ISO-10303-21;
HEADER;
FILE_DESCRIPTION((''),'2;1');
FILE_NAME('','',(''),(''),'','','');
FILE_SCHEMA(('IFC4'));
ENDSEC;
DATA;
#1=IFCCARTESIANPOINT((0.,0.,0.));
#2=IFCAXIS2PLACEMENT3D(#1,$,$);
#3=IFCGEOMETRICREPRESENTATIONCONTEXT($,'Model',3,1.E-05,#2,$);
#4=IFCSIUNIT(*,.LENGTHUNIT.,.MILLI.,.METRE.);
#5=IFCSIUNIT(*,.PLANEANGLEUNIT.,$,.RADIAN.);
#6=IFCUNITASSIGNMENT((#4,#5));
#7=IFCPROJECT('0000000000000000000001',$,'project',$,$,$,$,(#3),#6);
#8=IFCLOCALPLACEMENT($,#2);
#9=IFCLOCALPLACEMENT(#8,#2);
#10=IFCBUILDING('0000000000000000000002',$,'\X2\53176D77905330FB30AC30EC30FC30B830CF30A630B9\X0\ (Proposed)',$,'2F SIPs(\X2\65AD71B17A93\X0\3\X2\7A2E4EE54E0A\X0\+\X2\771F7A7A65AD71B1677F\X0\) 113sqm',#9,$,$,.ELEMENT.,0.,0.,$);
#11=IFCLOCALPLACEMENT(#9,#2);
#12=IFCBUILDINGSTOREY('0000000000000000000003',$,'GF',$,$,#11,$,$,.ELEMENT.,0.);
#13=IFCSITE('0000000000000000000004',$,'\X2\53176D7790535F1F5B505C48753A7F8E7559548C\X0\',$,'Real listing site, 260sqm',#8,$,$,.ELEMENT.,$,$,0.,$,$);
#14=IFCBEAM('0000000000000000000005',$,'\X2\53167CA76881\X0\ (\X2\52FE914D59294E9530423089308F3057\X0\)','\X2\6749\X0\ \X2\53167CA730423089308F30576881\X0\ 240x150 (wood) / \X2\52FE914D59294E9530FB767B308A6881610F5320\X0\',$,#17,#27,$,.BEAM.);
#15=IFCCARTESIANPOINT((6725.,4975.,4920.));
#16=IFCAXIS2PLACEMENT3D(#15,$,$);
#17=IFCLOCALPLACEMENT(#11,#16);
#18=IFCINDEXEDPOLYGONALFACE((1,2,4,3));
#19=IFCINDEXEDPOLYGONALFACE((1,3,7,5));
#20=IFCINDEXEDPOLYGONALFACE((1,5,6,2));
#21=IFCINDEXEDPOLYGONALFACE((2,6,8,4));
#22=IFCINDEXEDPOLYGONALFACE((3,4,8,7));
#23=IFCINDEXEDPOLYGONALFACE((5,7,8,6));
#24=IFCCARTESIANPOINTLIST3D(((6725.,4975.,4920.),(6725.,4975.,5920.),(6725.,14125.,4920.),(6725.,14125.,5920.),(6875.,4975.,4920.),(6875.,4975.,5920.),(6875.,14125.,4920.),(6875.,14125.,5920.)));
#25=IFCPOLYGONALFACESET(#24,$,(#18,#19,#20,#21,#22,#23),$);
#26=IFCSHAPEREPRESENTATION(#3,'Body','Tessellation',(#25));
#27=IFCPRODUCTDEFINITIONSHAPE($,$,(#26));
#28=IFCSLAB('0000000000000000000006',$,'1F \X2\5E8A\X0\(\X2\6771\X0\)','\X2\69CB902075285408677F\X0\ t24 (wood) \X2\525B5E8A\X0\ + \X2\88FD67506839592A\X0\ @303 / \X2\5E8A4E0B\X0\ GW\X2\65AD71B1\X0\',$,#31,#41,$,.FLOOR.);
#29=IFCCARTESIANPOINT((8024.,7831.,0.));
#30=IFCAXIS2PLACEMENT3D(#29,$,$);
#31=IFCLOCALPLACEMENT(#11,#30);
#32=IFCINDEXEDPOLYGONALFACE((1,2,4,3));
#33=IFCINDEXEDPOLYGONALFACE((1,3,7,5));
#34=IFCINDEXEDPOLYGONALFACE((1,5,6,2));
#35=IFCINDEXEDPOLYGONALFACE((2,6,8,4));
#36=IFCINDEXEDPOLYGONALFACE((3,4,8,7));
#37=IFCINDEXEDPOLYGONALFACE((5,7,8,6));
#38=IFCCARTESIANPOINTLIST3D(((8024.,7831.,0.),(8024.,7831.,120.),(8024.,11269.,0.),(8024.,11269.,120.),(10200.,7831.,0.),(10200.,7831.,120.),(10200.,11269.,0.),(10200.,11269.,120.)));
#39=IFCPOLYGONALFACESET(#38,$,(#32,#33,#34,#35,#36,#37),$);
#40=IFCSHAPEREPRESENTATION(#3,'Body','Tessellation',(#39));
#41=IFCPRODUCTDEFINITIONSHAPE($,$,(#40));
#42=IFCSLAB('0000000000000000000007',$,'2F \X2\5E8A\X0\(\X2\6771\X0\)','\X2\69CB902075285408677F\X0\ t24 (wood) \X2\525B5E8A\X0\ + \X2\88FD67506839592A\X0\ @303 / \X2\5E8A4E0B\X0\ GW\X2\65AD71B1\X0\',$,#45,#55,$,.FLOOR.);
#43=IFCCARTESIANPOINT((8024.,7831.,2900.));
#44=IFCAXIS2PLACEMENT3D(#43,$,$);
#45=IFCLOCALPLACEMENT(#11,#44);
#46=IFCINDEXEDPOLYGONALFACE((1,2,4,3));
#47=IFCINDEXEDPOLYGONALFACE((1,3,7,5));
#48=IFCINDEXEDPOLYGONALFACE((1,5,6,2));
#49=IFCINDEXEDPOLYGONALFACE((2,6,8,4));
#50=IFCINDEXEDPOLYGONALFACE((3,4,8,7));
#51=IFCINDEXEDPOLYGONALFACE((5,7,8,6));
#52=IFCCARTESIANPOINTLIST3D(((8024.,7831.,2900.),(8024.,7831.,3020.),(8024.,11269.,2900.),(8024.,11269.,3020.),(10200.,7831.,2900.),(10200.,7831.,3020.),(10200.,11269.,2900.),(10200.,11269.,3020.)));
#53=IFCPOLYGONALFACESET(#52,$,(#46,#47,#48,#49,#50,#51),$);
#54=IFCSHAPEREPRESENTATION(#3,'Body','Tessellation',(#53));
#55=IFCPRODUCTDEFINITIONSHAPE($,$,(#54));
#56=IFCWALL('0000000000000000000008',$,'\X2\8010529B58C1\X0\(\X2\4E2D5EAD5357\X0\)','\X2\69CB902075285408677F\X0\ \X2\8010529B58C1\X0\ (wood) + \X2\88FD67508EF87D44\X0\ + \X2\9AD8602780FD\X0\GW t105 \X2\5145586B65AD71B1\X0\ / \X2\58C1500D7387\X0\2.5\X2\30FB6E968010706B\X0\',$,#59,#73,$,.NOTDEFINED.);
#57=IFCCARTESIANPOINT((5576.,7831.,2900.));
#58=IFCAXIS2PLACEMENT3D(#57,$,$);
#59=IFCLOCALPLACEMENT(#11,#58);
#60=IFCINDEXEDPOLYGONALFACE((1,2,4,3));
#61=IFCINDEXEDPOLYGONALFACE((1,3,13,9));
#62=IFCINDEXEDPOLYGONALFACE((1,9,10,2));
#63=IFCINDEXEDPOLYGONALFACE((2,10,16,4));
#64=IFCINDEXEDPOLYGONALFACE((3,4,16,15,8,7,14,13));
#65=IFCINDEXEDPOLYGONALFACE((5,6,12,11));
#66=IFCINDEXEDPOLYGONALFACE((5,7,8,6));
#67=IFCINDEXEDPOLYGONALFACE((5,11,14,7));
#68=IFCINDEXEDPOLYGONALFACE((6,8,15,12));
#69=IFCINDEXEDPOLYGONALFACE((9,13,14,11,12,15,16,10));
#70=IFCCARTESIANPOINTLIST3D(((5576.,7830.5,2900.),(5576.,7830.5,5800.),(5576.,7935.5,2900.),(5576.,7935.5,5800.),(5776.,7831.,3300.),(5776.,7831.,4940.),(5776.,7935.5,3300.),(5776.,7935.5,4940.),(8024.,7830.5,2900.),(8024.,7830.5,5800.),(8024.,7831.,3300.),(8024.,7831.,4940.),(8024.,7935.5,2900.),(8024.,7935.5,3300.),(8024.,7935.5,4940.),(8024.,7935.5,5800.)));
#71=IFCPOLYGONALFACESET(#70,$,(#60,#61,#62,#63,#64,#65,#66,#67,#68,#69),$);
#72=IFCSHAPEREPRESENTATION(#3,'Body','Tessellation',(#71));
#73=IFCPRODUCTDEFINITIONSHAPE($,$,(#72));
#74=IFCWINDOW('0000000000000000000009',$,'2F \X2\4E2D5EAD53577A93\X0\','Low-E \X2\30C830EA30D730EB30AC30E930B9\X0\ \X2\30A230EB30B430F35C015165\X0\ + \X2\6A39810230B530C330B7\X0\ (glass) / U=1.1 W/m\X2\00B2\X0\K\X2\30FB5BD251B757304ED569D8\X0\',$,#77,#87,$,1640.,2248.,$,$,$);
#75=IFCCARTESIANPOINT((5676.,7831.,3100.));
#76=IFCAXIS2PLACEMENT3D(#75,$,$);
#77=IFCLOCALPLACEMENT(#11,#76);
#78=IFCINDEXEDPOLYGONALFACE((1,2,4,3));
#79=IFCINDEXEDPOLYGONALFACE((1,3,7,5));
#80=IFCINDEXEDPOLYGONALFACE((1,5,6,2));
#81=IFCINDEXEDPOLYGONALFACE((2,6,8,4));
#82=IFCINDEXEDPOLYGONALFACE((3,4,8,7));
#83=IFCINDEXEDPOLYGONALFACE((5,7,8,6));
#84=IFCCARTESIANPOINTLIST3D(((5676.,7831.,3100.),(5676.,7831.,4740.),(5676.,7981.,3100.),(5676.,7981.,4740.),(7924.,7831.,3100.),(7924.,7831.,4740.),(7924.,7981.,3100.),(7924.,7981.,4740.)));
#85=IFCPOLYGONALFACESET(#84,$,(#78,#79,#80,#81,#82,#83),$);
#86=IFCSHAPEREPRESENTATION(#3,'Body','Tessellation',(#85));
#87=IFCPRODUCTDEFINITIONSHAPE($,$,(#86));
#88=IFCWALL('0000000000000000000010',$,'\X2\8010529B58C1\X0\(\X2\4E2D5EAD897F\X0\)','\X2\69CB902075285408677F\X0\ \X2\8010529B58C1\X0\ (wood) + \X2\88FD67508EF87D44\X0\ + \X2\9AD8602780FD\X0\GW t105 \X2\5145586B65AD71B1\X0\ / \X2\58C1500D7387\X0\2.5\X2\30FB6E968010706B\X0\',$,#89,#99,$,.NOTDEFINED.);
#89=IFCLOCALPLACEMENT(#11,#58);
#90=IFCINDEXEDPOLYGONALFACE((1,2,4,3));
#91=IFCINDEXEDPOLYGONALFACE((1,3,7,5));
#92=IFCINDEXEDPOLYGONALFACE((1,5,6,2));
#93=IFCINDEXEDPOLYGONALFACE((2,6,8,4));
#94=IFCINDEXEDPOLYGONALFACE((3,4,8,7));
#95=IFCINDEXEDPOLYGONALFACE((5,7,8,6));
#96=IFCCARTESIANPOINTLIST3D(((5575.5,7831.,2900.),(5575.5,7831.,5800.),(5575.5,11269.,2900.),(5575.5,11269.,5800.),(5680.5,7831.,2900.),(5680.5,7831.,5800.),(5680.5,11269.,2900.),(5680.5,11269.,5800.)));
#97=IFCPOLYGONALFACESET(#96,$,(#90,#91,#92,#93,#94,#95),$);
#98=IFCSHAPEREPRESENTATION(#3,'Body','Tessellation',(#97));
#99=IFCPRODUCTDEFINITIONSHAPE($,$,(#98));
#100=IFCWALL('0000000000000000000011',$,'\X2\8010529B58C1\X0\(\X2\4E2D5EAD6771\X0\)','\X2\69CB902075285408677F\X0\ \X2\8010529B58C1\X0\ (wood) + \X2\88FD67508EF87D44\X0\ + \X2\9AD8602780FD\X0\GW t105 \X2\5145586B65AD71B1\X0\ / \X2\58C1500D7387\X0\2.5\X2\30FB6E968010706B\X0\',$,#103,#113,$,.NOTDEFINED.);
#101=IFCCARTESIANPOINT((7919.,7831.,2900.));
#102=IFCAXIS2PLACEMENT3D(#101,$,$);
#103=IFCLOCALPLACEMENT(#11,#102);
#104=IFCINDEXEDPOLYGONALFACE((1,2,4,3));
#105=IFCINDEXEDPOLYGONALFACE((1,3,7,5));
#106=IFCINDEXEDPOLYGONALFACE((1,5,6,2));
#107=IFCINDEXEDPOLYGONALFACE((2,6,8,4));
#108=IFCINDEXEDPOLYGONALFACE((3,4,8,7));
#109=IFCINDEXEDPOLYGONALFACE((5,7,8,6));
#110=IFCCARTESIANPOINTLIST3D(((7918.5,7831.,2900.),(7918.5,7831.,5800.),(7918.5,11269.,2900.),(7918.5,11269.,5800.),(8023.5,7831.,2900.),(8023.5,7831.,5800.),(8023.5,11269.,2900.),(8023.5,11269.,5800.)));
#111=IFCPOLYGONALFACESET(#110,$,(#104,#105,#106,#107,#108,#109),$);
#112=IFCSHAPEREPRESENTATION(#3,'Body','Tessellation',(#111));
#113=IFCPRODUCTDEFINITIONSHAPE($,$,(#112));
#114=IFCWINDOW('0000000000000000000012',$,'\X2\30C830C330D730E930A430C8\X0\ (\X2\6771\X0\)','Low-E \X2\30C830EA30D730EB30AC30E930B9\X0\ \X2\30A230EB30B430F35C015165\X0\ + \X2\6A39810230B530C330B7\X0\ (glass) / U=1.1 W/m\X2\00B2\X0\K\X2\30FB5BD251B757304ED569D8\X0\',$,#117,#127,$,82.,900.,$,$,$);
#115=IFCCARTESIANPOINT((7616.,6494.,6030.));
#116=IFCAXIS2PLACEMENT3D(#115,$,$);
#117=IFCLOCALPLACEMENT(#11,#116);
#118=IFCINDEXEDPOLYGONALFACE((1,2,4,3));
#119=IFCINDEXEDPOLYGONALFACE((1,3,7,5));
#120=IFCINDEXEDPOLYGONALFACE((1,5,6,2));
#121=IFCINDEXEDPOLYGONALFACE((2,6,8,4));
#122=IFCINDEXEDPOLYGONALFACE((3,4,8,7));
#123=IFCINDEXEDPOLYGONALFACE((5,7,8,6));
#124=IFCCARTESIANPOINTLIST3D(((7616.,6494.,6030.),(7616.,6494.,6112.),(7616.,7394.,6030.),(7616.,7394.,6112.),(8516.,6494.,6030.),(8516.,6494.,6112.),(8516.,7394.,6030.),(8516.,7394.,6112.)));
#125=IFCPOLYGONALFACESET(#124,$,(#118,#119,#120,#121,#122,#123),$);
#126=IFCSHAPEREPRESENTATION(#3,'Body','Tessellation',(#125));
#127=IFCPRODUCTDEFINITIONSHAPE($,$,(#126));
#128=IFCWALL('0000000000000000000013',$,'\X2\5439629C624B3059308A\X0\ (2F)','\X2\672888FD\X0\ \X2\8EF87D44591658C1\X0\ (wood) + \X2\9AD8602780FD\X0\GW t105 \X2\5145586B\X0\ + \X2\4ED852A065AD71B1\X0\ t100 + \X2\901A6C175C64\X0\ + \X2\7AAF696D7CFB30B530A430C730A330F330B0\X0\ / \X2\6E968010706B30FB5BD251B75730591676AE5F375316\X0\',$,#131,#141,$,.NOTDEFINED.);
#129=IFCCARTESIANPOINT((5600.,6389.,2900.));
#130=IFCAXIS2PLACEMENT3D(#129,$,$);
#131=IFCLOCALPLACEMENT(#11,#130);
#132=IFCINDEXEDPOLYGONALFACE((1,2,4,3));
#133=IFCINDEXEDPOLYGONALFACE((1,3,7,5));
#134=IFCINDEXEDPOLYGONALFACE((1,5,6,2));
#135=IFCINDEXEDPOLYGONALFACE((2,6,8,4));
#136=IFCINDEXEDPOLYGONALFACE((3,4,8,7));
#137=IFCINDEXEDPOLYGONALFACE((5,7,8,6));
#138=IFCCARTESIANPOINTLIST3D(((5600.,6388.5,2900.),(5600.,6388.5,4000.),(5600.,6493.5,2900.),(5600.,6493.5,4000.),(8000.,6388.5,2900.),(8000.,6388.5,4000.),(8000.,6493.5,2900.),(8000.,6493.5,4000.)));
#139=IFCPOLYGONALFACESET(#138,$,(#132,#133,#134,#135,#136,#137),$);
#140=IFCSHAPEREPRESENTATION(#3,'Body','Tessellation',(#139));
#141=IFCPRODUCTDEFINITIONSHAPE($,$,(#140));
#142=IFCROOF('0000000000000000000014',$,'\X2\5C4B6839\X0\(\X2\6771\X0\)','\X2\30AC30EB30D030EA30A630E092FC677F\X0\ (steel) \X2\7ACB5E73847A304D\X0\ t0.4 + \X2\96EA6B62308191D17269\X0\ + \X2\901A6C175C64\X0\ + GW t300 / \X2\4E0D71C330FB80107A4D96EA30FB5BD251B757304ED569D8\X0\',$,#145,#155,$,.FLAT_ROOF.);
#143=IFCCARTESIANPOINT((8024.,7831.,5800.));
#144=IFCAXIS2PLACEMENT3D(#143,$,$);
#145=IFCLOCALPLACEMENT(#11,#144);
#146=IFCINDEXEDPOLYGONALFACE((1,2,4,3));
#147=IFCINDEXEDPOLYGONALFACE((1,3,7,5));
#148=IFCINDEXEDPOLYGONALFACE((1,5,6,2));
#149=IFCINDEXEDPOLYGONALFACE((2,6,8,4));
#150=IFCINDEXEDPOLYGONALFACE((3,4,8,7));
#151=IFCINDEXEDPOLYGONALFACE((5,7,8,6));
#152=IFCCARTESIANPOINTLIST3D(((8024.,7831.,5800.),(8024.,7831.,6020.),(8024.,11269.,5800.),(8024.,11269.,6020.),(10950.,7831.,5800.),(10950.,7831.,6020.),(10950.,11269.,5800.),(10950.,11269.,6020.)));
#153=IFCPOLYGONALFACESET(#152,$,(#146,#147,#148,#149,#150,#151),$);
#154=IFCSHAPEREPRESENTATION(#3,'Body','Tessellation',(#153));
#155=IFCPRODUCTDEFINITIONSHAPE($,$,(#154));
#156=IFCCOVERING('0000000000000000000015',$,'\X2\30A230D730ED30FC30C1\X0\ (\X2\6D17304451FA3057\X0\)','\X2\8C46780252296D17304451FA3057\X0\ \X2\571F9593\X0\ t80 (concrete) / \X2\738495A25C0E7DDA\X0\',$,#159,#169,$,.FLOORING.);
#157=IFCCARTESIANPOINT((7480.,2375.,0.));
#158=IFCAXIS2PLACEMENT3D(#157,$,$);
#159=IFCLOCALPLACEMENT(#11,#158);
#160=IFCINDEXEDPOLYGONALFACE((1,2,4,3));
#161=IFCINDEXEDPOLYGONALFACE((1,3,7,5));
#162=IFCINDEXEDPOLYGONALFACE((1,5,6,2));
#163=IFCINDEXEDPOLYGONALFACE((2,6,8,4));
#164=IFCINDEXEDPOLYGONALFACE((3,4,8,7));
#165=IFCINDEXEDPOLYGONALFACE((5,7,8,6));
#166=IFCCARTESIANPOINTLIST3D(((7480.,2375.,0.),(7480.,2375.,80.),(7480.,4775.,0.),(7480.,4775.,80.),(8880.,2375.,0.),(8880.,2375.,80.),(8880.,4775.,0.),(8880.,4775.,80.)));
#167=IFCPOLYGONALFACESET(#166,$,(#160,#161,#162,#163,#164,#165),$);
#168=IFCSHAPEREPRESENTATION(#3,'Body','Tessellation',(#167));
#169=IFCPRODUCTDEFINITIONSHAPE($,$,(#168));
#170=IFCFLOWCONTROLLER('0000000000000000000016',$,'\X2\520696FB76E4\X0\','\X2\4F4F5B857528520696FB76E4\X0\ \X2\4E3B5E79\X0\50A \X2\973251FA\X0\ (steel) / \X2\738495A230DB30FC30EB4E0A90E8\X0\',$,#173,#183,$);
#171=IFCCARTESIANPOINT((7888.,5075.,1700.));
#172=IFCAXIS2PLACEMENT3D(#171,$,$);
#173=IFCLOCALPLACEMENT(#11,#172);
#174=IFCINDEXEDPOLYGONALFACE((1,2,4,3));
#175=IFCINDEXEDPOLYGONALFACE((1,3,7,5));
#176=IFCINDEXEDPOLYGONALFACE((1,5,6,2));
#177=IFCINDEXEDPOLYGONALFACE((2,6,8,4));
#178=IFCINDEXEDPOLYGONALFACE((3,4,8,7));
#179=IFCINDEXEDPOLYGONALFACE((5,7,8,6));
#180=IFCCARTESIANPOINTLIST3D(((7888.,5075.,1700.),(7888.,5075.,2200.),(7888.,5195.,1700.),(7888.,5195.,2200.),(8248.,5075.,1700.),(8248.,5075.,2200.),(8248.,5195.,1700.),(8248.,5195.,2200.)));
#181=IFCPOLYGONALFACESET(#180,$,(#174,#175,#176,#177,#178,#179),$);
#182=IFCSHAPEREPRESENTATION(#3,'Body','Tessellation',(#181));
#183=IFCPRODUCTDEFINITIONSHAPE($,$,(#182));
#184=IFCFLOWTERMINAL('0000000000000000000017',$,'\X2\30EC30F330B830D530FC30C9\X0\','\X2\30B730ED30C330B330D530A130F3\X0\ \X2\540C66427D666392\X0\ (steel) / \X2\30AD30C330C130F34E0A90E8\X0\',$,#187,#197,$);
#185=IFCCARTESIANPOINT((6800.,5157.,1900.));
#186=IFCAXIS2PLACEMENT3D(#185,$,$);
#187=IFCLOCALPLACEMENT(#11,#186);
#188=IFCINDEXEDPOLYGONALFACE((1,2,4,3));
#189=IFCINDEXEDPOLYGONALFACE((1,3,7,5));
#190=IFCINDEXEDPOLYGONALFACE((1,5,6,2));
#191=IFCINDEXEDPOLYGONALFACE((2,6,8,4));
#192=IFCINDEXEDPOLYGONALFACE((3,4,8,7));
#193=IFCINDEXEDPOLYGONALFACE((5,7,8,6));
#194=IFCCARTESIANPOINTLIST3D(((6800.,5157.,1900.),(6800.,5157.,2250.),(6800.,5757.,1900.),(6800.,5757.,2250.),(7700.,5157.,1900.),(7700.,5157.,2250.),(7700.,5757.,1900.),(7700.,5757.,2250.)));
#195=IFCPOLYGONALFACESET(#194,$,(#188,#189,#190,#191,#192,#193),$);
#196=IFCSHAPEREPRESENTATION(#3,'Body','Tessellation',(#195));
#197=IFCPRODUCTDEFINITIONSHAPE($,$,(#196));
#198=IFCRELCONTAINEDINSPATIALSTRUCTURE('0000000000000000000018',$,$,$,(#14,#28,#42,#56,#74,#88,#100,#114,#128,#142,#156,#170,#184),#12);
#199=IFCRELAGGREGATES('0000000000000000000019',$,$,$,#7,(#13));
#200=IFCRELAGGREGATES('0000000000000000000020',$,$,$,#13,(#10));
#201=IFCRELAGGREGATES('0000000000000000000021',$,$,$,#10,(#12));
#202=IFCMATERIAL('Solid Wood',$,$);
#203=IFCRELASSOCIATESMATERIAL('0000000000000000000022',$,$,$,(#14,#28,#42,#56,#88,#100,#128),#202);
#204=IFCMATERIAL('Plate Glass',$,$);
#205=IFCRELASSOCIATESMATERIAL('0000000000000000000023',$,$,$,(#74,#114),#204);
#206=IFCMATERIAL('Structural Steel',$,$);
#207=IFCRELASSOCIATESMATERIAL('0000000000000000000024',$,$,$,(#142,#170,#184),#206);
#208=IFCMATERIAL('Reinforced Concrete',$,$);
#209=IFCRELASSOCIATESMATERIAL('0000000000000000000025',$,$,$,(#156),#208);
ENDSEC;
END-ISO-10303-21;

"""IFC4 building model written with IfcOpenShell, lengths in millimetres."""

from ifc_helpers import new_model, si_unit, frame, frame_2d, origin, place, context, project, spatial, rectangle, extrude, material, element, fill, save


model = new_model("IFC4")

# Units and contexts
model_context = context("Model", 3, precision=1e-05, world=origin())
ifc_project = project(units=[si_unit("LENGTHUNIT", "METRE", prefix="MILLI"), si_unit("PLANEANGLEUNIT", "RADIAN")], contexts=[model_context])

# Site, building, storey
site_placement = place(None, origin())
site = spatial("IfcSite", under=ifc_project, at=site_placement, Name="北海道弟子屈町美留和", ObjectType="Real listing site, 260sqm", CompositionType="ELEMENT", RefElevation=0.0)
building_placement = place(site_placement, origin())
building = spatial("IfcBuilding", under=site, at=building_placement, Name="北海道・ガレージハウス (Proposed)", ObjectType="2F SIPs(断熱窓3種以上+真空断熱板) 113sqm", CompositionType="ELEMENT", ElevationOfRefHeight=0.0, ElevationOfTerrain=0.0)
storey_placement = place(building_placement, origin())
storey = spatial("IfcBuildingStorey", under=building, at=storey_placement, Name="GF", CompositionType="ELEMENT", Elevation=0.0)

# Shared definitions
ifc_material_1 = material(Name="Solid Wood")

# Beam
beam_placement = place(storey_placement, frame((6725.0, 4975.0, 4920.0)))
element("IfcBeam", 1, at=beam_placement, inside=storey, material=ifc_material_1, Name="化粧梁 (勾配天井あらわし)", Description="杉 化粧あらわし梁 240x150 (wood) / 勾配天井・登り梁意匠", PredefinedType="BEAM", context=model_context, shape_type="SweptSolid", body=[
    extrude(rectangle(XDim=150.0, YDim=9150.0, at=frame_2d((75.0, 4575.0))), frame((6725.0, 4975.0, 4920.0)), (0.0, 0.0, 1.0), 1000.0),
])

# Slabs
slab_1_placement = place(storey_placement, frame((8024.0, 7831.0, 0.0)))
element("IfcSlab", 2, at=slab_1_placement, inside=storey, material=ifc_material_1, Name="1F 床(東)", Description="構造用合板 t24 (wood) 剛床 + 製材根太 @303 / 床下 GW断熱", PredefinedType="FLOOR", context=model_context, shape_type="SweptSolid", body=[
    extrude(rectangle(XDim=2176.0, YDim=3438.0, at=frame_2d((1088.0, 1719.0))), frame((8024.0, 7831.0, 0.0)), (0.0, 0.0, 1.0), 120.0),
])
slab_2_placement = place(storey_placement, frame((8024.0, 7831.0, 2900.0)))
element("IfcSlab", 3, at=slab_2_placement, inside=storey, material=ifc_material_1, Name="2F 床(東)", Description="構造用合板 t24 (wood) 剛床 + 製材根太 @303 / 床下 GW断熱", PredefinedType="FLOOR", context=model_context, shape_type="SweptSolid", body=[
    extrude(rectangle(XDim=2176.0, YDim=3438.0, at=frame_2d((1088.0, 1719.0))), frame((8024.0, 7831.0, 2900.0)), (0.0, 0.0, 1.0), 120.0),
])

# Wall, opening, window
wall_1_placement = place(storey_placement, frame((5576.0, 7831.0, 2900.0)))
wall_1 = element("IfcWall", 4, at=wall_1_placement, inside=storey, material=ifc_material_1, Name="耐力壁(中庭南)", Description="構造用合板 耐力壁 (wood) + 製材軸組 + 高性能GW t105 充填断熱 / 壁倍率2.5・準耐火", PredefinedType="NOTDEFINED", context=model_context, shape_type="SweptSolid", body=[
    extrude(rectangle(XDim=2448.0, YDim=105.0, at=frame_2d((1224.0, 52.0))), frame((5576.0, 7831.0, 2900.0)), (0.0, 0.0, 1.0), 2900.0),
])
opening_placement = place(storey_placement, frame((5676.0, 7831.0, 3100.0)))
opening = element("IfcOpeningElement", 5, at=opening_placement, cuts=wall_1, PredefinedType="NOTDEFINED", context=model_context, shape_type="SweptSolid", body=[
    extrude(rectangle(XDim=2248.0, YDim=150.0, at=frame_2d((1124.0, 75.0))), frame((5676.0, 7831.0, 3100.0)), (0.0, 0.0, 1.0), 1640.0),
])
ifc_material_2 = material(Name="Plate Glass")
window_1_placement = place(storey_placement, frame((5676.0, 7831.0, 3100.0)))
window_1 = element("IfcWindow", 6, at=window_1_placement, inside=storey, material=ifc_material_2, Name="2F 中庭南窓", Description="Low-E トリプルガラス アルゴン封入 + 樹脂サッシ (glass) / U=1.1 W/m²K・寒冷地仕様", OverallHeight=1640.0, OverallWidth=2248.0, context=model_context, shape_type="SweptSolid", body=[
    extrude(rectangle(XDim=2248.0, YDim=150.0, at=frame_2d((1124.0, 75.0))), frame((5676.0, 7831.0, 3100.0)), (0.0, 0.0, 1.0), 1640.0),
])
fill(opening, window_1)

# Walls
wall_2_placement = place(storey_placement, frame((5576.0, 7831.0, 2900.0)))
element("IfcWall", 7, at=wall_2_placement, inside=storey, material=ifc_material_1, Name="耐力壁(中庭西)", Description="構造用合板 耐力壁 (wood) + 製材軸組 + 高性能GW t105 充填断熱 / 壁倍率2.5・準耐火", PredefinedType="NOTDEFINED", context=model_context, shape_type="SweptSolid", body=[
    extrude(rectangle(XDim=105.0, YDim=3438.0, at=frame_2d((52.0, 1719.0))), frame((5576.0, 7831.0, 2900.0)), (0.0, 0.0, 1.0), 2900.0),
])
wall_3_placement = place(storey_placement, frame((7919.0, 7831.0, 2900.0)))
element("IfcWall", 8, at=wall_3_placement, inside=storey, material=ifc_material_1, Name="耐力壁(中庭東)", Description="構造用合板 耐力壁 (wood) + 製材軸組 + 高性能GW t105 充填断熱 / 壁倍率2.5・準耐火", PredefinedType="NOTDEFINED", context=model_context, shape_type="SweptSolid", body=[
    extrude(rectangle(XDim=105.0, YDim=3438.0, at=frame_2d((52.0, 1719.0))), frame((7919.0, 7831.0, 2900.0)), (0.0, 0.0, 1.0), 2900.0),
])

# Window
window_2_placement = place(storey_placement, frame((7616.0, 6494.0, 6030.0)))
element("IfcWindow", 9, at=window_2_placement, inside=storey, material=ifc_material_2, Name="トップライト (東)", Description="Low-E トリプルガラス アルゴン封入 + 樹脂サッシ (glass) / U=1.1 W/m²K・寒冷地仕様", OverallHeight=82.0, OverallWidth=900.0, context=model_context, shape_type="SweptSolid", body=[
    extrude(rectangle(XDim=900.0, YDim=900.0, at=frame_2d((450.0, 450.0))), frame((7616.0, 6494.0, 6030.0)), (0.0, 0.0, 1.0), 82.0),
])

# Wall
wall_4_placement = place(storey_placement, frame((5600.0, 6389.0, 2900.0)))
element("IfcWall", 10, at=wall_4_placement, inside=storey, material=ifc_material_1, Name="吹抜手すり (2F)", Description="木製 軸組外壁 (wood) + 高性能GW t105 充填 + 付加断熱 t100 + 通気層 + 窯業系サイディング / 準耐火・寒冷地外皮強化", PredefinedType="NOTDEFINED", context=model_context, shape_type="SweptSolid", body=[
    extrude(rectangle(XDim=2400.0, YDim=105.0, at=frame_2d((1200.0, 52.0))), frame((5600.0, 6389.0, 2900.0)), (0.0, 0.0, 1.0), 1100.0),
])

# Roof
ifc_material_3 = material(Name="Structural Steel")
for number, where, name in (
    (11, (8024.0, 7831.0, 5800.0), "屋根(東)"),
):
    element("IfcRoof", number, at=place(storey_placement, frame(where)), inside=storey, material=ifc_material_3, Name=name, Description="ガルバリウム鋼板 (steel) 立平葺き t0.4 + 雪止め金物 + 通気層 + GW t300 / 不燃・耐積雪・寒冷地仕様", PredefinedType="FLAT_ROOF", context=model_context, shape_type="SweptSolid", body=[
        extrude(rectangle(XDim=2926.0, YDim=3438.0, at=frame_2d((1463.0, 1719.0))), frame((8024.0, 7831.0, 5800.0)), (0.0, 0.0, 1.0), 220.0),
    ])

# Covering
ifc_material_4 = material(Name="Reinforced Concrete")
covering_placement = place(storey_placement, frame((7480.0, 2375.0, 0.0)))
element("IfcCovering", 12, at=covering_placement, inside=storey, material=ifc_material_4, Name="アプローチ (洗い出し)", Description="豆砂利洗い出し 土間 t80 (concrete) / 玄関導線", PredefinedType="FLOORING", context=model_context, shape_type="SweptSolid", body=[
    extrude(rectangle(XDim=1400.0, YDim=2400.0, at=frame_2d((700.0, 1200.0))), frame((7480.0, 2375.0, 0.0)), (0.0, 0.0, 1.0), 80.0),
])

# Flow controller
flow_controller_placement = place(storey_placement, frame((7888.0, 5075.0, 1700.0)))
element("IfcFlowController", 13, at=flow_controller_placement, inside=storey, material=ifc_material_3, Name="分電盤", Description="住宅用分電盤 主幹50A 露出 (steel) / 玄関ホール上部", context=model_context, shape_type="SweptSolid", body=[
    extrude(rectangle(XDim=360.0, YDim=120.0, at=frame_2d((180.0, 60.0))), frame((7888.0, 5075.0, 1700.0)), (0.0, 0.0, 1.0), 500.0),
])

# Flow terminal
flow_terminal_1_placement = place(storey_placement, frame((6800.0, 5157.0, 1900.0)))
element("IfcFlowTerminal", 14, at=flow_terminal_1_placement, inside=storey, material=ifc_material_3, Name="レンジフード", Description="シロッコファン 同時給排 (steel) / キッチン上部", context=model_context, shape_type="SweptSolid", body=[
    extrude(rectangle(XDim=900.0, YDim=600.0, at=frame_2d((450.0, 300.0))), frame((6800.0, 5157.0, 1900.0)), (0.0, 0.0, 1.0), 350.0),
])

save(model, "model.ifc")
